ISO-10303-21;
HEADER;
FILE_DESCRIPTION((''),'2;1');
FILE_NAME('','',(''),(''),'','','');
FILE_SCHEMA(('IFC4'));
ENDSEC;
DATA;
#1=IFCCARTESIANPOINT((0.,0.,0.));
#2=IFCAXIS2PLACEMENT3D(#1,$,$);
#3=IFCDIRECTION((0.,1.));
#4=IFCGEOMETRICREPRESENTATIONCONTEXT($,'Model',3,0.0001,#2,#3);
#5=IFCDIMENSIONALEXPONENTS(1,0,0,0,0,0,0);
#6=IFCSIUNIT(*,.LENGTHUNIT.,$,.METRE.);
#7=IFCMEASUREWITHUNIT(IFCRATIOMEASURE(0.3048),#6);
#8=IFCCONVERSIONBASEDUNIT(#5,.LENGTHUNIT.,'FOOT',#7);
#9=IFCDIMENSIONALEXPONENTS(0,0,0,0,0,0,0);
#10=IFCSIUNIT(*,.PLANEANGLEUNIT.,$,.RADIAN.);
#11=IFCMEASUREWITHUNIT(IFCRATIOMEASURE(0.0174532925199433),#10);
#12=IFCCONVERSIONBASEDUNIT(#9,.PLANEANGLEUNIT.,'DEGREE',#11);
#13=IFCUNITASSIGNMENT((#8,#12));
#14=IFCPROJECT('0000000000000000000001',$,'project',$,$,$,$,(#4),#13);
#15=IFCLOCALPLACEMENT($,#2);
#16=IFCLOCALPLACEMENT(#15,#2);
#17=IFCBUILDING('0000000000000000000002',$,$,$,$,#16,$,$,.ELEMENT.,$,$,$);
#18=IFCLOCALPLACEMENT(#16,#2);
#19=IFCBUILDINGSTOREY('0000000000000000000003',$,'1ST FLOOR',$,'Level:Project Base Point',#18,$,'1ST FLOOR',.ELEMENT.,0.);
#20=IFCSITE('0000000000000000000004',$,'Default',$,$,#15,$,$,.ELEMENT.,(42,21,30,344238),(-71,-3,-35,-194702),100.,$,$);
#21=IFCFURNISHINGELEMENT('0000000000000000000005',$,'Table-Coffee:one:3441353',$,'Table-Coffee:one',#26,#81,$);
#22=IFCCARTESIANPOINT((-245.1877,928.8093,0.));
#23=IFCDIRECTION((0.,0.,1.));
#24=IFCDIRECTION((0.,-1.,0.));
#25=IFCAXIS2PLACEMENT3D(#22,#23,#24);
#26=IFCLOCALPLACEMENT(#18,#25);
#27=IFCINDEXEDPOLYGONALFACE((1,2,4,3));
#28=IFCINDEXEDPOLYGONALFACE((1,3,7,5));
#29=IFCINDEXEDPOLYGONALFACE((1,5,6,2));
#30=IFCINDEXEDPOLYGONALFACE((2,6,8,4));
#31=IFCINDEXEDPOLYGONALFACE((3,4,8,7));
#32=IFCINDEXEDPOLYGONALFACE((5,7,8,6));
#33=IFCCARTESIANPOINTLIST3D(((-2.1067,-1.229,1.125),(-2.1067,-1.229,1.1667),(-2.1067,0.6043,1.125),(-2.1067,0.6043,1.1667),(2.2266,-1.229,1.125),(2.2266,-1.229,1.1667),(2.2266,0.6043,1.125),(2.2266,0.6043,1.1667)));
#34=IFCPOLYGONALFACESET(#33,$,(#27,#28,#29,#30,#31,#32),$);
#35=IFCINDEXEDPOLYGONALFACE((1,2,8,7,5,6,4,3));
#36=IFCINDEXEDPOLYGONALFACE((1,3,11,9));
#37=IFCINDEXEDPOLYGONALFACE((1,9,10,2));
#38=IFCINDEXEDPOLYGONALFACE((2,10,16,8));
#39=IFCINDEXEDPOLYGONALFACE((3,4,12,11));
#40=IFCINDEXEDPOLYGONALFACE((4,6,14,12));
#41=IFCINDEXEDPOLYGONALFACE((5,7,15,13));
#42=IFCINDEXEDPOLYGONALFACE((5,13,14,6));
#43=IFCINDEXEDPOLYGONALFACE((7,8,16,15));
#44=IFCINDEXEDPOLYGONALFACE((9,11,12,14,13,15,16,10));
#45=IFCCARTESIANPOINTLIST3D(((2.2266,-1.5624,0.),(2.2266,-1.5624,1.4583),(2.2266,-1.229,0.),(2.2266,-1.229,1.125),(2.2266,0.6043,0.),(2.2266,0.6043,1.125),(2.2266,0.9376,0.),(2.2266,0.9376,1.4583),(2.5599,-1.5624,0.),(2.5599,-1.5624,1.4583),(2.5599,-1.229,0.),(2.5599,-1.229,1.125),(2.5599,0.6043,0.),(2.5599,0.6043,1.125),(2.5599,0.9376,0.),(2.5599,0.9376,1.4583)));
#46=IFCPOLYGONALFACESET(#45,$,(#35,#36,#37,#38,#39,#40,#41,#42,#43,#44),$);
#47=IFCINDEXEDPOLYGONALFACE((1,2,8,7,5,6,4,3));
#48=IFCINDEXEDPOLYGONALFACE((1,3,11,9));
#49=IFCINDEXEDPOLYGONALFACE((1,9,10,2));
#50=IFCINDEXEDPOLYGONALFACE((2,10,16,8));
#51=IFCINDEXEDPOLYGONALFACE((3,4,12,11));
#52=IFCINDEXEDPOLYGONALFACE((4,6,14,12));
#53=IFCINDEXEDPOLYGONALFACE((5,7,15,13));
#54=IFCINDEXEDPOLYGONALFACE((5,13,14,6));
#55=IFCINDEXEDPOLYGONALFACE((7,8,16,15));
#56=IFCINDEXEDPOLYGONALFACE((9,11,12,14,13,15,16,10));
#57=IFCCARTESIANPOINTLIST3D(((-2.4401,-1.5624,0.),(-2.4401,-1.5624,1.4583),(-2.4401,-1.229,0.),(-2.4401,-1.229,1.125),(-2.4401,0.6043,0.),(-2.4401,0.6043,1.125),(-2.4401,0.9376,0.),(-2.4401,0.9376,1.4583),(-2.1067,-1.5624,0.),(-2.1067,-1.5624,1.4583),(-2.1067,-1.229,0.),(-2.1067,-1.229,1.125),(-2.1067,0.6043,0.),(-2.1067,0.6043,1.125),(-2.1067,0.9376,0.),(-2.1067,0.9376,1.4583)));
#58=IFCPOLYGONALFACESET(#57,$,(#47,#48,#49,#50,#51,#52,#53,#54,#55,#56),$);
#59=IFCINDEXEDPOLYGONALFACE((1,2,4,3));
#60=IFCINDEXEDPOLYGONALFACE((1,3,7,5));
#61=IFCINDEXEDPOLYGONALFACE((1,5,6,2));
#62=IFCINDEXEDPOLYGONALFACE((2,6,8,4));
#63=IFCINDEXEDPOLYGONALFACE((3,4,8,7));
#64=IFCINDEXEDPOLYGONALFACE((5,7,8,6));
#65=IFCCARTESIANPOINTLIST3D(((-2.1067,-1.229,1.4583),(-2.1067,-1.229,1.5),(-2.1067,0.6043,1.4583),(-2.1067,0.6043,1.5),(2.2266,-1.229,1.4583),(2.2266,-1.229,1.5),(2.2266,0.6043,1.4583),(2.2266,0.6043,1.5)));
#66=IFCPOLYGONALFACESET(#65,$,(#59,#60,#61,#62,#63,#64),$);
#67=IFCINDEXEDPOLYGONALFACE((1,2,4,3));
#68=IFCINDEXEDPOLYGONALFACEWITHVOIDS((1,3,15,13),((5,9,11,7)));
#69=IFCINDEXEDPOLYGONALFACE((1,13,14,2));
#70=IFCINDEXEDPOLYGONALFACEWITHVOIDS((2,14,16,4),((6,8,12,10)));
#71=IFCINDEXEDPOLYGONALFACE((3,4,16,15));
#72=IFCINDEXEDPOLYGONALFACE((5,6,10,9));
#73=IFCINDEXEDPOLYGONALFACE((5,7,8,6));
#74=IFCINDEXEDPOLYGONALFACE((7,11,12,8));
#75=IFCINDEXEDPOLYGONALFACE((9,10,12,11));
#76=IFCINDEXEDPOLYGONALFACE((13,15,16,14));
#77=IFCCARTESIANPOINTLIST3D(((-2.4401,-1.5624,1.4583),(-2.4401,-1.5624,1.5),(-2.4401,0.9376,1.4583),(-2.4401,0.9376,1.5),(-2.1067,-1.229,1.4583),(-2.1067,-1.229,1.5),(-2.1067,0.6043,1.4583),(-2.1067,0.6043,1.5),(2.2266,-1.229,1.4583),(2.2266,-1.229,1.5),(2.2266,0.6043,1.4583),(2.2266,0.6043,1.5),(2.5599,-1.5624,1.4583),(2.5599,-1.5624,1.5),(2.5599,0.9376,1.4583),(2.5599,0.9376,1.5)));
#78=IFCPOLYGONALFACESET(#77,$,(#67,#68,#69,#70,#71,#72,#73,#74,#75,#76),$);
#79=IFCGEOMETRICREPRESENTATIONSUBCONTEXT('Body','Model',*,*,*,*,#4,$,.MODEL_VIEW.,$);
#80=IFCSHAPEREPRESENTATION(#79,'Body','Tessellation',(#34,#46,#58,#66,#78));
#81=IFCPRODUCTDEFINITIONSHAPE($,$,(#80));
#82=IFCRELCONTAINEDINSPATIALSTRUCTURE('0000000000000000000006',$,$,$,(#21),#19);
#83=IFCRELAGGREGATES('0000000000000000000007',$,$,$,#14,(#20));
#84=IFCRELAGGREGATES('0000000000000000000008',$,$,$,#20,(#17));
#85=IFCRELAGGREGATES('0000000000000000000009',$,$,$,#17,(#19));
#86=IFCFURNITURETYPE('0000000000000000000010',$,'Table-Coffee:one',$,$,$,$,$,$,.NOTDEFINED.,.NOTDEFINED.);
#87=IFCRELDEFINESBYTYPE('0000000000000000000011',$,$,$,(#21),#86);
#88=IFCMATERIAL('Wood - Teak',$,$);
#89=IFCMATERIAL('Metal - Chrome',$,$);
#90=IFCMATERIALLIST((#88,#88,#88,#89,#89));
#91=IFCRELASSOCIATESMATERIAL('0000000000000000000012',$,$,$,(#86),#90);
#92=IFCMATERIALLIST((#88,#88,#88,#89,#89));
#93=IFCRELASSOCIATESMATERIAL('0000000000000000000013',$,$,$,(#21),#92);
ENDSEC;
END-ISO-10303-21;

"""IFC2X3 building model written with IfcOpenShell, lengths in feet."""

from ifc_helpers import new_model, entity, si_unit, converted_unit, direction, frame, origin, origin_2d_with_axis, place, context, subcontext, project, spatial, polyline, rectangle, outline, extrude, source, transform, mapped, material, material_list, type_object, type_shapes, element, save


model = new_model("IFC2X3")

# Units and contexts
model_context = context("Model", 3, precision=0.0001, world=origin(), true_north=direction((0.0, 1.0)))
body_context = subcontext(model_context, "Body", "Model", "MODEL_VIEW")
ifc_project = project(units=[converted_unit("LENGTHUNIT", "FOOT", entity("IfcRatioMeasure", 0.3048), si_unit("LENGTHUNIT", "METRE"), dimensions=[1, 0, 0, 0, 0, 0, 0]), converted_unit("PLANEANGLEUNIT", "DEGREE", entity("IfcRatioMeasure", 0.0174532925199433), si_unit("PLANEANGLEUNIT", "RADIAN"), dimensions=[0, 0, 0, 0, 0, 0, 0])], contexts=[model_context])

# Site, building, storey
site_placement = place(None, origin())
site = spatial("IfcSite", under=ifc_project, at=site_placement, Name="Default", CompositionType="ELEMENT", RefLatitude=(42, 21, 30, 344238), RefLongitude=(-71, -3, -35, -194702), RefElevation=100.0)
building_placement = place(site_placement, origin())
building = spatial("IfcBuilding", under=site, at=building_placement, CompositionType="ELEMENT")
storey_placement = place(building_placement, origin())
storey = spatial("IfcBuildingStorey", under=building, at=storey_placement, Name="1ST FLOOR", ObjectType="Level:Project Base Point", LongName="1ST FLOOR", CompositionType="ELEMENT", Elevation=0.0)

# Furnishing element
ifc_material_1 = material(Name="Wood - Teak")
ifc_material_2 = material(Name="Metal - Chrome")
ifc_material_list_1 = material_list([ifc_material_1, ifc_material_1, ifc_material_1, ifc_material_2, ifc_material_2])
ifc_material_list_2 = material_list([ifc_material_1, ifc_material_1, ifc_material_1, ifc_material_2, ifc_material_2])
furniture_type_1 = type_object("IfcFurnitureType", Name="Table-Coffee:one", material=ifc_material_list_2)
shared_shape_1 = source(origin(), body_context, "Body", "SweptSolid", [
    extrude(rectangle(XDim=1.8333, YDim=4.3333, at=origin_2d_with_axis()), frame((0.0599, -0.3124, 1.125), z_axis=(0.0, 0.0, 1.0), x_axis=(0.0, 1.0, 0.0)), (0.0, 0.0, 1.0), 0.0417),
    extrude(outline(polyline([(-1.25, -0.6458), (-0.9167, -0.6458), (-0.9167, 0.4792), (0.9167, 0.4792), (0.9167, -0.6458), (1.25, -0.6458), (1.25, 0.8125), (-1.25, 0.8125), (-1.25, -0.6458)])), frame((2.2266, -0.3124, 0.6458), z_axis=(1.0, 0.0, 0.0), x_axis=(0.0, 1.0, 0.0)), (0.0, 0.0, 1.0), 0.3333),
    extrude(outline(polyline([(-0.8125, -1.25), (0.6458, -1.25), (0.6458, -0.9167), (-0.4792, -0.9167), (-0.4792, 0.9167), (0.6458, 0.9167), (0.6458, 1.25), (-0.8125, 1.25), (-0.8125, -1.25)])), frame((-2.4401, -0.3124, 0.6458), z_axis=(1.0, 0.0, 0.0), x_axis=(0.0, 0.0, -1.0)), (0.0, 0.0, 1.0), 0.3333),
    extrude(rectangle(XDim=1.8333, YDim=4.3333, at=origin_2d_with_axis()), frame((0.0599, -0.3124, 1.4583), z_axis=(0.0, 0.0, 1.0), x_axis=(0.0, 1.0, 0.0)), (0.0, 0.0, 1.0), 0.0417),
    extrude(outline(polyline([(-1.25, -2.5), (1.25, -2.5), (1.25, 2.5), (-1.25, 2.5), (-1.25, -2.5)]), holes=[polyline([(-0.9167, -2.1667), (-0.9167, 2.1667), (0.9167, 2.1667), (0.9167, -2.1667), (-0.9167, -2.1667)])]), frame((0.0599, -0.3124, 1.4583), z_axis=(0.0, 0.0, 1.0), x_axis=(0.0, 1.0, 0.0)), (0.0, 0.0, 1.0), 0.0417),
])
type_shapes(furniture_type_1, [shared_shape_1])
furnishing_1_placement = place(storey_placement, frame((-245.1877, 928.8093, 0.0), z_axis=(0.0, 0.0, 1.0), x_axis=(0.0, -1.0, 0.0)))
element("IfcFurnishingElement", 1, at=furnishing_1_placement, inside=storey, type_object=furniture_type_1, material=ifc_material_list_1, Name="Table-Coffee:one:3441353", ObjectType="Table-Coffee:one", context=body_context, shape_type="MappedRepresentation", body=[
    mapped(shared_shape_1, transform((0.0, 0.0, 0.0), scale=1.0)),
])

save(model, "model.ifc")
